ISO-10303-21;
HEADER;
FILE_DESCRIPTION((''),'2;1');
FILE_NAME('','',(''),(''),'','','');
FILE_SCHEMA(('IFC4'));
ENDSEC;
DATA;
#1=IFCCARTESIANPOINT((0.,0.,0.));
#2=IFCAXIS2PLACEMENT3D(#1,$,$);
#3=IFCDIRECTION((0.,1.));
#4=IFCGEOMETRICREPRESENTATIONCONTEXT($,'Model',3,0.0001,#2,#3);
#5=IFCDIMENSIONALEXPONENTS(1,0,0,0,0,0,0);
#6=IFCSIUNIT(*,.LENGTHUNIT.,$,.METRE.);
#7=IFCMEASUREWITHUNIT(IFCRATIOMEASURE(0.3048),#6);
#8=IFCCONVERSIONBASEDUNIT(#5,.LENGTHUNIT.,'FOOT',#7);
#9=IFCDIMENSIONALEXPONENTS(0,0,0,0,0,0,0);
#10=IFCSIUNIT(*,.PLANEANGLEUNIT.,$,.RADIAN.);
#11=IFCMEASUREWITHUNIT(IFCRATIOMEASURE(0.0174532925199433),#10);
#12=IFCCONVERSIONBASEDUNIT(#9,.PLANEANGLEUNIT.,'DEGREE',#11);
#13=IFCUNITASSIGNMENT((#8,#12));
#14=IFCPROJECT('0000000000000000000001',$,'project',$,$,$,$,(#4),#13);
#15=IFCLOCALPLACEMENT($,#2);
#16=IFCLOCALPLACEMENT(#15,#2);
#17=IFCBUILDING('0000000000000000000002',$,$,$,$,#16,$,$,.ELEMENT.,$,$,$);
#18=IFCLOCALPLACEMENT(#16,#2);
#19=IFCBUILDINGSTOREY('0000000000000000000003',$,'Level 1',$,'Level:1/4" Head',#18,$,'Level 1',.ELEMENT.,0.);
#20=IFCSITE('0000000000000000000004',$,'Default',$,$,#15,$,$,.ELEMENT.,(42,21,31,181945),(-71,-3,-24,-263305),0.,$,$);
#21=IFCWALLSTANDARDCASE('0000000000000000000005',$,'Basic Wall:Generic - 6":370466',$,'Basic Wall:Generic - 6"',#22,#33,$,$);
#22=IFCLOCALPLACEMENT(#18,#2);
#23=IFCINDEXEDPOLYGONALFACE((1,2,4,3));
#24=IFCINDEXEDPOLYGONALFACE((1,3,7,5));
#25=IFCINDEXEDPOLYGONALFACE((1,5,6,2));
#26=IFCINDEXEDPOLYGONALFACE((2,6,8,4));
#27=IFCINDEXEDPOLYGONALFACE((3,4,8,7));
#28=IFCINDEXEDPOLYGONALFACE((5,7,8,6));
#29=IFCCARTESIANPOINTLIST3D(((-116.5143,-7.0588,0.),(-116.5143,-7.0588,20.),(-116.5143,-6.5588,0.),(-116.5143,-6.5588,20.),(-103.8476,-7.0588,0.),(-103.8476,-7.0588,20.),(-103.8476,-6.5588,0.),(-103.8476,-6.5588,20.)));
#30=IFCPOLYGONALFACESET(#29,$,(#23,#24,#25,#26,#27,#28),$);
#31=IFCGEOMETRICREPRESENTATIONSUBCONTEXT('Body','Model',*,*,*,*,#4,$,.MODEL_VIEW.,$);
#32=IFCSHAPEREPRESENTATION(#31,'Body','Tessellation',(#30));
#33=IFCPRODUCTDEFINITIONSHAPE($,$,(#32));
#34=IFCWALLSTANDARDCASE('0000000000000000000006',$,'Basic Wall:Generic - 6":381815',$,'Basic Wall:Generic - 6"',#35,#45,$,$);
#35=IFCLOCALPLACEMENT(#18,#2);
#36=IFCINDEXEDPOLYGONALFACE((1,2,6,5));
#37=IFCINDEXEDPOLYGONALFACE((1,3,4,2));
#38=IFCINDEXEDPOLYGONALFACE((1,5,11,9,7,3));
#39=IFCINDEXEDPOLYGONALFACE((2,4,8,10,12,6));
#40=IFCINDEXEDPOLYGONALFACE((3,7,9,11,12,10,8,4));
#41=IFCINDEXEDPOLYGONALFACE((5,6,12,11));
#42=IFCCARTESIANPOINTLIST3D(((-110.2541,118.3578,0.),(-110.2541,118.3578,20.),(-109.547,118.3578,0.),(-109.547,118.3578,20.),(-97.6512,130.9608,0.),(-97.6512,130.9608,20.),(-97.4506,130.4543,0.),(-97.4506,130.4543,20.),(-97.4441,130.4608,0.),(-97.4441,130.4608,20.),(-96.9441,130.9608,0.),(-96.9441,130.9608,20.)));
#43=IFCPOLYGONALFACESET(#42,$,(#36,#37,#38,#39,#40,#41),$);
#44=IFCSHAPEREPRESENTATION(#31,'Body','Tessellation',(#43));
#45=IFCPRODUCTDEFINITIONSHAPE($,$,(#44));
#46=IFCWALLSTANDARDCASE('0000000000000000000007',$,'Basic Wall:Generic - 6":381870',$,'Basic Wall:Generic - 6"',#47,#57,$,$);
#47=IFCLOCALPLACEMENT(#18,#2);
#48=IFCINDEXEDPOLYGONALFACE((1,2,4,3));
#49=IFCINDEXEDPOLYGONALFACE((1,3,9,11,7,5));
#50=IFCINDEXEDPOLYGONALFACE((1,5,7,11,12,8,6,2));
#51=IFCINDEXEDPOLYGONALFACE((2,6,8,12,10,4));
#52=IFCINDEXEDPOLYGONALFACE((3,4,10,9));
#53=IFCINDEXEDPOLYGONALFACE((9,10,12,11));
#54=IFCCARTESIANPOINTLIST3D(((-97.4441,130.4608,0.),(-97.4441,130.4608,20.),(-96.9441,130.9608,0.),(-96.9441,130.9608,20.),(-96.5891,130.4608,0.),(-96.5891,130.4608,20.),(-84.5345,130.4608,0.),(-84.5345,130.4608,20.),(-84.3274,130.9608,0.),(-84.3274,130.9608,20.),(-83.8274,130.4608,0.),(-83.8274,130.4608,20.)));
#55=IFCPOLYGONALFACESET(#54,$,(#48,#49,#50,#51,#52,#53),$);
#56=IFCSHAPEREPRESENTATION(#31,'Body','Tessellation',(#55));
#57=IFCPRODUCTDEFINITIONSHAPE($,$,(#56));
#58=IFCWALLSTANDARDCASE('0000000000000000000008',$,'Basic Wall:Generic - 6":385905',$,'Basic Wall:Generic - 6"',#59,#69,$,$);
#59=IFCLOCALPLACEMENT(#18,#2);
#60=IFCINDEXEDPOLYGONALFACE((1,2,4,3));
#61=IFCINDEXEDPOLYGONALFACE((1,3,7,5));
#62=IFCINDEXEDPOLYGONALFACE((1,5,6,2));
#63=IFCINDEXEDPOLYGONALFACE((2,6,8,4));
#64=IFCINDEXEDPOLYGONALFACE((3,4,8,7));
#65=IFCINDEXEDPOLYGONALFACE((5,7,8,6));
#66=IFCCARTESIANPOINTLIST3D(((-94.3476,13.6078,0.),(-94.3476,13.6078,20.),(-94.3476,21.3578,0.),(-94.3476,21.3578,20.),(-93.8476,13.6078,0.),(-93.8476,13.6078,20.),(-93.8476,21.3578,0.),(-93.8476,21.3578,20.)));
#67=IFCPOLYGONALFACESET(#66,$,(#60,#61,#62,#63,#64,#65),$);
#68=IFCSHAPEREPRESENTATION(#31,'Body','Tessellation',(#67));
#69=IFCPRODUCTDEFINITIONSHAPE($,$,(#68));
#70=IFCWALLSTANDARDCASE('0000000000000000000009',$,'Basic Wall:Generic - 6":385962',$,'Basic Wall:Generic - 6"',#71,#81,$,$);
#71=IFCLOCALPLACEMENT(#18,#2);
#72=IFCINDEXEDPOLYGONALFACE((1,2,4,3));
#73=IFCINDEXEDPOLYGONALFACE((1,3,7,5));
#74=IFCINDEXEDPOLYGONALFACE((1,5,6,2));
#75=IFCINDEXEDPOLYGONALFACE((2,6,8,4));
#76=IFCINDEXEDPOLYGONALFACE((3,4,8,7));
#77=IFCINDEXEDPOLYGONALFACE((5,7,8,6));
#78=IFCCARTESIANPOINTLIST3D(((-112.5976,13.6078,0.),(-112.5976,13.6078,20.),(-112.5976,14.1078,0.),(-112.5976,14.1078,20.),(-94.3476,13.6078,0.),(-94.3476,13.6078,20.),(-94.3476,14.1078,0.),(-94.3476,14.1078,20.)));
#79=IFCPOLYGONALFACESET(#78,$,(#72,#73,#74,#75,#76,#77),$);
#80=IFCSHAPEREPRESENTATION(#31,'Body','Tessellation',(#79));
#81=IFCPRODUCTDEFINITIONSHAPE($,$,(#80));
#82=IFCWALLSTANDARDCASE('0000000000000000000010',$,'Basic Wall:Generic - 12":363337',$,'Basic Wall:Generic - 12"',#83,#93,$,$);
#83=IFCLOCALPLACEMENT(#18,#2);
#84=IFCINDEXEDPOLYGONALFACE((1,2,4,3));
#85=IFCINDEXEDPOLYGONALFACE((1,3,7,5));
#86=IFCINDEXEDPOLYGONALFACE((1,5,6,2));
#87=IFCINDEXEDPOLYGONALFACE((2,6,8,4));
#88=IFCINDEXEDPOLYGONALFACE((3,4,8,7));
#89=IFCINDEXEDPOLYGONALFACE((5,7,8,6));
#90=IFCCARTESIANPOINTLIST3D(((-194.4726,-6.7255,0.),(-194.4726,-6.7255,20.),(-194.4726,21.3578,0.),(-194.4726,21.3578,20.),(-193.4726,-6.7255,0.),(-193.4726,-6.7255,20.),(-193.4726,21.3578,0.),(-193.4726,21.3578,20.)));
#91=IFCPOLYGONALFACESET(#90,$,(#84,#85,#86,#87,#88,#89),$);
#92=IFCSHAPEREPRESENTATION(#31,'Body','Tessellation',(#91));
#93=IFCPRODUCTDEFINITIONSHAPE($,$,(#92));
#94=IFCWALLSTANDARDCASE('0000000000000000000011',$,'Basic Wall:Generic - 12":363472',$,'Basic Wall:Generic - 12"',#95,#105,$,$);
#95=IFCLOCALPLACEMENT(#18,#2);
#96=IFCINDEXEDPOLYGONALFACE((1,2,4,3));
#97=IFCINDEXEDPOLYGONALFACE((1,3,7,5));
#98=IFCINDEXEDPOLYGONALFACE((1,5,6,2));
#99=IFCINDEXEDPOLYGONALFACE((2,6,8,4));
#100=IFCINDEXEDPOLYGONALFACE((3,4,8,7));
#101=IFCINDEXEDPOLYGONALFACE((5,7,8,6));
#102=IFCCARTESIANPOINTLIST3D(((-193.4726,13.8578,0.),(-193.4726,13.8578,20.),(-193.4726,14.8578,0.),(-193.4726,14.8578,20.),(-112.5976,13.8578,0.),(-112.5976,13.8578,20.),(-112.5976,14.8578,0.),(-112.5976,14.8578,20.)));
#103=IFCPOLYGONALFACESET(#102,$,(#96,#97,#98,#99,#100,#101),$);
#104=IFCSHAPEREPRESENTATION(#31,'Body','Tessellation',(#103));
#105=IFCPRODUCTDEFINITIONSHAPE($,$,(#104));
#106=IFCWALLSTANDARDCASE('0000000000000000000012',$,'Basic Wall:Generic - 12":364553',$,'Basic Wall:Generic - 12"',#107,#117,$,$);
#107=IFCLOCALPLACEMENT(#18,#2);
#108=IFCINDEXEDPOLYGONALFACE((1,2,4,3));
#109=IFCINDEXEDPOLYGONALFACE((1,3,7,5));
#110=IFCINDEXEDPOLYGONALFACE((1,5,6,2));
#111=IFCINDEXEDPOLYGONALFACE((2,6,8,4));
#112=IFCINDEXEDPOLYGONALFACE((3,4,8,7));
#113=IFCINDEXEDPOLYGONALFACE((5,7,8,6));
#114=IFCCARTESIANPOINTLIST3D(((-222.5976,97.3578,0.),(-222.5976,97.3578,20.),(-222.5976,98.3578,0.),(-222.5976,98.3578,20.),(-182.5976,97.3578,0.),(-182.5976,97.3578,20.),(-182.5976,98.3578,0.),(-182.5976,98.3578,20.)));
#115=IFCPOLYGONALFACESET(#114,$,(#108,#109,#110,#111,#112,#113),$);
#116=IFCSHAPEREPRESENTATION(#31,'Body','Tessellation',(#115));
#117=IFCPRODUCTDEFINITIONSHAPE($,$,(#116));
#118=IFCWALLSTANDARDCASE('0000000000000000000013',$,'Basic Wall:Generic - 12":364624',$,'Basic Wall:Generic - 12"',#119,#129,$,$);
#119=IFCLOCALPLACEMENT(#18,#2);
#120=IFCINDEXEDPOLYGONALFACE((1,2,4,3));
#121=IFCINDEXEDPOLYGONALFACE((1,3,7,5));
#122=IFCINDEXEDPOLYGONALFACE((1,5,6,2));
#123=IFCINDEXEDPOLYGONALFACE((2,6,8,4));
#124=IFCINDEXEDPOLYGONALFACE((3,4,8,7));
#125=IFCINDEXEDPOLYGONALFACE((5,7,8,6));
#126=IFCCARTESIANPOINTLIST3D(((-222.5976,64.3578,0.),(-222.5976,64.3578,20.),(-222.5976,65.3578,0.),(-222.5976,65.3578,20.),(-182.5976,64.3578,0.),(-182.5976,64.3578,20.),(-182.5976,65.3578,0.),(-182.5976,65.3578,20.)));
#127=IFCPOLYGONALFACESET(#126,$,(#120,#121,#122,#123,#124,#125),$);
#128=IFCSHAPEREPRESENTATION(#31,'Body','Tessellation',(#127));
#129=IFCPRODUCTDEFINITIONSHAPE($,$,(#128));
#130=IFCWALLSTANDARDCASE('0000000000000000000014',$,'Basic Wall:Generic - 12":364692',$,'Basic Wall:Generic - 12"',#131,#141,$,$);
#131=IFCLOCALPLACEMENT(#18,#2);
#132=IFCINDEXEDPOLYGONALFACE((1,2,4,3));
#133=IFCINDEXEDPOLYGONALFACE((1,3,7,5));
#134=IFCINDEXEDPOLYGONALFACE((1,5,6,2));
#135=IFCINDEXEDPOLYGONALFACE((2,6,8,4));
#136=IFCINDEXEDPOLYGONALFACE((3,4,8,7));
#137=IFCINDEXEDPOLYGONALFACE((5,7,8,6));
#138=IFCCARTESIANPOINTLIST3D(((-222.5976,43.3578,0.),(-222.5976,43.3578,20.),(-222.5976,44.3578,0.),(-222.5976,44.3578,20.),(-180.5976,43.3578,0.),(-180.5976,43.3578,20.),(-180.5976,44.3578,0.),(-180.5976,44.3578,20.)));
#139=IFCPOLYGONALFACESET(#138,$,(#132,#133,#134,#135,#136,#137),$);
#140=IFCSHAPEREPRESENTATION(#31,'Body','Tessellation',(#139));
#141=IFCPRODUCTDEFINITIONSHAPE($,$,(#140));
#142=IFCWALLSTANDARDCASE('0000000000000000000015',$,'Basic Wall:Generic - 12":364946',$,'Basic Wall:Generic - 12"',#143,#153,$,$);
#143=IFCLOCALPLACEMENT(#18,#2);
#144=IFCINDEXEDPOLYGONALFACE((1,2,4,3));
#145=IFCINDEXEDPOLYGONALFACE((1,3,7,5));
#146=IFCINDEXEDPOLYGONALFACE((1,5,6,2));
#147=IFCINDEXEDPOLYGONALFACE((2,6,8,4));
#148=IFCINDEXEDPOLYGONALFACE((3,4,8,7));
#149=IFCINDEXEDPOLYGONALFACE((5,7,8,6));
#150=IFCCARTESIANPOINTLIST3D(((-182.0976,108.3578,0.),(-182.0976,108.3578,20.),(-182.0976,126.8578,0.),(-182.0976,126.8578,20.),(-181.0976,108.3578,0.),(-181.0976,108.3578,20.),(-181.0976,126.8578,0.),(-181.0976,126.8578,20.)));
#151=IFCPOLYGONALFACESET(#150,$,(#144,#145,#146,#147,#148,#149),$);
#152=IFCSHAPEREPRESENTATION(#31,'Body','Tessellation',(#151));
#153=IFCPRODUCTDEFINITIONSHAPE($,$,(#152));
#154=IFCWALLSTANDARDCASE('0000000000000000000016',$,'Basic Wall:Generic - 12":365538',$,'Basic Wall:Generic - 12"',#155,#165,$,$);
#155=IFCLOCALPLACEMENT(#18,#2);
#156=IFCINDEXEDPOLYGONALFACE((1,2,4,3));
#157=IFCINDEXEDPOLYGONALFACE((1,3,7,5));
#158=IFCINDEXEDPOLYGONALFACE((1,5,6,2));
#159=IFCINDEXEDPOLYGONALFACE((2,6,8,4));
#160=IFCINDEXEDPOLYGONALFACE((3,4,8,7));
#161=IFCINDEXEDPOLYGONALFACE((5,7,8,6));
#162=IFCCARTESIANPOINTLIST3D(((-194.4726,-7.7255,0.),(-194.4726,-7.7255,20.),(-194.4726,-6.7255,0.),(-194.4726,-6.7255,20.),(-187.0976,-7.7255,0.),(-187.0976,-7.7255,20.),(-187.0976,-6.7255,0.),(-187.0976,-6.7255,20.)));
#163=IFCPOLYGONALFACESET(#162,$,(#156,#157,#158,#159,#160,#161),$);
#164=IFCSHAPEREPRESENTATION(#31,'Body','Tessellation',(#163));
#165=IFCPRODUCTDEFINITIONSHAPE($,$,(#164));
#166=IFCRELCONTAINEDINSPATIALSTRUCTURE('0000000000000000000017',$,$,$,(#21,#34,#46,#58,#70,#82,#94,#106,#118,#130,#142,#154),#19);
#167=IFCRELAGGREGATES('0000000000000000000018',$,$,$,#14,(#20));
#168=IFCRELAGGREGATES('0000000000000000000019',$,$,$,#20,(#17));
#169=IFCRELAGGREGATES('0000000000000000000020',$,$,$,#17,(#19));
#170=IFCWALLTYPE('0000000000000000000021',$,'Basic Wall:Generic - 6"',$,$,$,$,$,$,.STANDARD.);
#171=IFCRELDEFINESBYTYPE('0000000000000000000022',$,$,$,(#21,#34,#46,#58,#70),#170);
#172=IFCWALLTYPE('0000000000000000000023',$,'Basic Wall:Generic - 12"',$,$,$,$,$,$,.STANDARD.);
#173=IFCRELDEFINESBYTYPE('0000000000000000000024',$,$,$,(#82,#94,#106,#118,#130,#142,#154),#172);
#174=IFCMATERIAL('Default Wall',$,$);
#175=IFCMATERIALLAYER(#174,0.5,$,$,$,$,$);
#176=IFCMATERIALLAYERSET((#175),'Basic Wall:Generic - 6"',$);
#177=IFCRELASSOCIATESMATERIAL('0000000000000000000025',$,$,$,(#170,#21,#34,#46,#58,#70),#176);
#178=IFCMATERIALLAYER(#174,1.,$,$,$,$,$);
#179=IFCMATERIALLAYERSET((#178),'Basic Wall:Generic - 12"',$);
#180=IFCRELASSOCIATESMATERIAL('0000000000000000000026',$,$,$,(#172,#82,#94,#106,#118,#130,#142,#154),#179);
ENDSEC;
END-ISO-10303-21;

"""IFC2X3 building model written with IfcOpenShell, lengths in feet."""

from ifc_helpers import new_model, entity, si_unit, converted_unit, direction, frame, frame_2d, origin, place, context, subcontext, project, spatial, polyline, rectangle, outline, extrude, material, layer, layer_set, layer_usage, type_object, element, save


model = new_model("IFC2X3")

# Units and contexts
model_context = context("Model", 3, precision=0.0001, world=origin(), true_north=direction((0.0, 1.0)))
body_context = subcontext(model_context, "Body", "Model", "MODEL_VIEW")
ifc_project = project(units=[converted_unit("LENGTHUNIT", "FOOT", entity("IfcRatioMeasure", 0.3048), si_unit("LENGTHUNIT", "METRE"), dimensions=[1, 0, 0, 0, 0, 0, 0]), converted_unit("PLANEANGLEUNIT", "DEGREE", entity("IfcRatioMeasure", 0.0174532925199433), si_unit("PLANEANGLEUNIT", "RADIAN"), dimensions=[0, 0, 0, 0, 0, 0, 0])], contexts=[model_context])

# Site, building, storey
site_placement = place(None, origin())
site = spatial("IfcSite", under=ifc_project, at=site_placement, Name="Default", CompositionType="ELEMENT", RefLatitude=(42, 21, 31, 181945), RefLongitude=(-71, -3, -24, -263305), RefElevation=0.0)
building_placement = place(site_placement, origin())
building = spatial("IfcBuilding", under=site, at=building_placement, CompositionType="ELEMENT")
storey_placement = place(building_placement, origin())
storey = spatial("IfcBuildingStorey", under=building, at=storey_placement, Name="Level 1", ObjectType="Level:1/4\" Head", LongName="Level 1", CompositionType="ELEMENT", Elevation=0.0)

# Walls
ifc_material = material(Name="Default Wall")
ifc_layer_1 = layer(ifc_material, 0.5)
ifc_layer_set_1 = layer_set([ifc_layer_1], Name="Basic Wall:Generic - 6\"")
wall_type_1 = type_object("IfcWallType", Name="Basic Wall:Generic - 6\"", PredefinedType="STANDARD", material=ifc_layer_set_1)
ifc_layer_usage_1 = layer_usage(ifc_layer_set_1, "AXIS2", "NEGATIVE", 0.25)
wall_1_placement = place(storey_placement, frame((-116.5143, -6.8088, 0.0)))
element("IfcWallStandardCase", 1, at=wall_1_placement, inside=storey, type_object=wall_type_1, material=ifc_layer_usage_1, Name="Basic Wall:Generic - 6\":370466", ObjectType="Basic Wall:Generic - 6\"", context=body_context, shape_type="SweptSolid", body=[
    extrude(rectangle(XDim=12.6667, YDim=0.5, at=frame_2d((6.3333, 0.0), x_axis=(-1.0, 0.0))), origin(), (0.0, 0.0, 1.0), 20.0),
])
ifc_layer_usage_2 = layer_usage(ifc_layer_set_1, "AXIS2", "NEGATIVE", 0.25)
wall_2_placement = place(storey_placement, frame((-110.0773, 118.1811, 0.0), z_axis=(0.0, 0.0, 1.0), x_axis=(0.707107, 0.707107, 0.0)))
element("IfcWallStandardCase", 2, at=wall_2_placement, inside=storey, type_object=wall_type_1, material=ifc_layer_usage_2, Name="Basic Wall:Generic - 6\":381815", ObjectType="Basic Wall:Generic - 6\"", context=body_context, shape_type="SweptSolid", body=[
    extrude(outline(polyline([(18.3233, -0.25), (17.8233, 0.25), (0.0, 0.25), (0.5, -0.25), (17.6069, -0.25), (17.6162, -0.25), (18.3233, -0.25)])), origin(), (0.0, 0.0, 1.0), 20.0),
])
ifc_layer_usage_3 = layer_usage(ifc_layer_set_1, "AXIS2", "NEGATIVE", 0.25)
wall_3_placement = place(storey_placement, frame((-97.4441, 130.7108, 0.0)))
element("IfcWallStandardCase", 3, at=wall_3_placement, inside=storey, type_object=wall_type_1, material=ifc_layer_usage_3, Name="Basic Wall:Generic - 6\":381870", ObjectType="Basic Wall:Generic - 6\"", context=body_context, shape_type="SweptSolid", body=[
    extrude(outline(polyline([(13.6166, -0.25), (13.1166, 0.25), (0.5, 0.25), (0.0, -0.25), (0.855, -0.25), (12.9095, -0.25), (13.6166, -0.25)])), origin(), (0.0, 0.0, 1.0), 20.0),
])
ifc_layer_usage_4 = layer_usage(ifc_layer_set_1, "AXIS2", "NEGATIVE", 0.25)
wall_4_placement = place(storey_placement, frame((-94.0976, 21.3578, 0.0), z_axis=(0.0, 0.0, 1.0), x_axis=(0.0, -1.0, 0.0)))
element("IfcWallStandardCase", 4, at=wall_4_placement, inside=storey, type_object=wall_type_1, material=ifc_layer_usage_4, Name="Basic Wall:Generic - 6\":385905", ObjectType="Basic Wall:Generic - 6\"", context=body_context, shape_type="SweptSolid", body=[
    extrude(rectangle(XDim=7.75, YDim=0.5, at=frame_2d((3.875, 0.0), x_axis=(-1.0, 0.0))), origin(), (0.0, 0.0, 1.0), 20.0),
])
ifc_layer_usage_5 = layer_usage(ifc_layer_set_1, "AXIS2", "NEGATIVE", 0.25)
wall_5_placement = place(storey_placement, frame((-94.3476, 13.8578, 0.0), z_axis=(0.0, 0.0, 1.0), x_axis=(-1.0, 0.0, 0.0)))
element("IfcWallStandardCase", 5, at=wall_5_placement, inside=storey, type_object=wall_type_1, material=ifc_layer_usage_5, Name="Basic Wall:Generic - 6\":385962", ObjectType="Basic Wall:Generic - 6\"", context=body_context, shape_type="SweptSolid", body=[
    extrude(rectangle(XDim=18.25, YDim=0.5, at=frame_2d((9.125, 0.0), x_axis=(-1.0, 0.0))), origin(), (0.0, 0.0, 1.0), 20.0),
])
ifc_layer_2 = layer(ifc_material, 1.0)
ifc_layer_set_2 = layer_set([ifc_layer_2], Name="Basic Wall:Generic - 12\"")
ifc_layer_usage_6 = layer_usage(ifc_layer_set_2, "AXIS2", "NEGATIVE", 0.5)
wall_type_2 = type_object("IfcWallType", Name="Basic Wall:Generic - 12\"", PredefinedType="STANDARD", material=ifc_layer_set_2)
wall_6_placement = place(storey_placement, frame((-193.9726, 21.3578, 0.0), z_axis=(0.0, 0.0, 1.0), x_axis=(0.0, -1.0, 0.0)))
element("IfcWallStandardCase", 6, at=wall_6_placement, inside=storey, type_object=wall_type_2, material=ifc_layer_usage_6, Name="Basic Wall:Generic - 12\":363337", ObjectType="Basic Wall:Generic - 12\"", context=body_context, shape_type="SweptSolid", body=[
    extrude(rectangle(XDim=28.0833, YDim=1.0, at=frame_2d((14.0417, 0.0), x_axis=(-1.0, 0.0))), origin(), (0.0, 0.0, 1.0), 20.0),
])
ifc_layer_usage_7 = layer_usage(ifc_layer_set_2, "AXIS2", "NEGATIVE", 0.5)
wall_7_placement = place(storey_placement, frame((-193.4726, 14.3578, 0.0)))
element("IfcWallStandardCase", 7, at=wall_7_placement, inside=storey, type_object=wall_type_2, material=ifc_layer_usage_7, Name="Basic Wall:Generic - 12\":363472", ObjectType="Basic Wall:Generic - 12\"", context=body_context, shape_type="SweptSolid", body=[
    extrude(rectangle(XDim=80.875, YDim=1.0, at=frame_2d((40.4375, 0.0), x_axis=(-1.0, 0.0))), origin(), (0.0, 0.0, 1.0), 20.0),
])
ifc_layer_usage_8 = layer_usage(ifc_layer_set_2, "AXIS2", "NEGATIVE", 0.5)
wall_8_placement = place(storey_placement, frame((-222.5976, 97.8578, 0.0)))
element("IfcWallStandardCase", 8, at=wall_8_placement, inside=storey, type_object=wall_type_2, material=ifc_layer_usage_8, Name="Basic Wall:Generic - 12\":364553", ObjectType="Basic Wall:Generic - 12\"", context=body_context, shape_type="SweptSolid", body=[
    extrude(rectangle(XDim=40.0, YDim=1.0, at=frame_2d((20.0, 0.0), x_axis=(-1.0, 0.0))), origin(), (0.0, 0.0, 1.0), 20.0),
])
ifc_layer_usage_9 = layer_usage(ifc_layer_set_2, "AXIS2", "NEGATIVE", 0.5)
wall_9_placement = place(storey_placement, frame((-222.5976, 64.8578, 0.0)))
element("IfcWallStandardCase", 9, at=wall_9_placement, inside=storey, type_object=wall_type_2, material=ifc_layer_usage_9, Name="Basic Wall:Generic - 12\":364624", ObjectType="Basic Wall:Generic - 12\"", context=body_context, shape_type="SweptSolid", body=[
    extrude(rectangle(XDim=40.0, YDim=1.0, at=frame_2d((20.0, 0.0), x_axis=(-1.0, 0.0))), origin(), (0.0, 0.0, 1.0), 20.0),
])
ifc_layer_usage_10 = layer_usage(ifc_layer_set_2, "AXIS2", "NEGATIVE", 0.5)
wall_10_placement = place(storey_placement, frame((-222.5976, 43.8578, 0.0)))
element("IfcWallStandardCase", 10, at=wall_10_placement, inside=storey, type_object=wall_type_2, material=ifc_layer_usage_10, Name="Basic Wall:Generic - 12\":364692", ObjectType="Basic Wall:Generic - 12\"", context=body_context, shape_type="SweptSolid", body=[
    extrude(rectangle(XDim=42.0, YDim=1.0, at=frame_2d((21.0, 0.0), x_axis=(-1.0, 0.0))), origin(), (0.0, 0.0, 1.0), 20.0),
])
ifc_layer_usage_11 = layer_usage(ifc_layer_set_2, "AXIS2", "NEGATIVE", 0.5)
wall_11_placement = place(storey_placement, frame((-181.5976, 108.3578, 0.0), z_axis=(0.0, 0.0, 1.0), x_axis=(0.0, 1.0, 0.0)))
element("IfcWallStandardCase", 11, at=wall_11_placement, inside=storey, type_object=wall_type_2, material=ifc_layer_usage_11, Name="Basic Wall:Generic - 12\":364946", ObjectType="Basic Wall:Generic - 12\"", context=body_context, shape_type="SweptSolid", body=[
    extrude(rectangle(XDim=18.5, YDim=1.0, at=frame_2d((9.25, 0.0), x_axis=(-1.0, 0.0))), origin(), (0.0, 0.0, 1.0), 20.0),
])
ifc_layer_usage_12 = layer_usage(ifc_layer_set_2, "AXIS2", "NEGATIVE", 0.5)
wall_12_placement = place(storey_placement, frame((-187.0976, -7.2255, 0.0), z_axis=(0.0, 0.0, 1.0), x_axis=(-1.0, 0.0, 0.0)))
element("IfcWallStandardCase", 12, at=wall_12_placement, inside=storey, type_object=wall_type_2, material=ifc_layer_usage_12, Name="Basic Wall:Generic - 12\":365538", ObjectType="Basic Wall:Generic - 12\"", context=body_context, shape_type="SweptSolid", body=[
    extrude(rectangle(XDim=7.375, YDim=1.0, at=frame_2d((3.6875, 0.0), x_axis=(-1.0, 0.0))), origin(), (0.0, 0.0, 1.0), 20.0),
])

save(model, "model.ifc")
